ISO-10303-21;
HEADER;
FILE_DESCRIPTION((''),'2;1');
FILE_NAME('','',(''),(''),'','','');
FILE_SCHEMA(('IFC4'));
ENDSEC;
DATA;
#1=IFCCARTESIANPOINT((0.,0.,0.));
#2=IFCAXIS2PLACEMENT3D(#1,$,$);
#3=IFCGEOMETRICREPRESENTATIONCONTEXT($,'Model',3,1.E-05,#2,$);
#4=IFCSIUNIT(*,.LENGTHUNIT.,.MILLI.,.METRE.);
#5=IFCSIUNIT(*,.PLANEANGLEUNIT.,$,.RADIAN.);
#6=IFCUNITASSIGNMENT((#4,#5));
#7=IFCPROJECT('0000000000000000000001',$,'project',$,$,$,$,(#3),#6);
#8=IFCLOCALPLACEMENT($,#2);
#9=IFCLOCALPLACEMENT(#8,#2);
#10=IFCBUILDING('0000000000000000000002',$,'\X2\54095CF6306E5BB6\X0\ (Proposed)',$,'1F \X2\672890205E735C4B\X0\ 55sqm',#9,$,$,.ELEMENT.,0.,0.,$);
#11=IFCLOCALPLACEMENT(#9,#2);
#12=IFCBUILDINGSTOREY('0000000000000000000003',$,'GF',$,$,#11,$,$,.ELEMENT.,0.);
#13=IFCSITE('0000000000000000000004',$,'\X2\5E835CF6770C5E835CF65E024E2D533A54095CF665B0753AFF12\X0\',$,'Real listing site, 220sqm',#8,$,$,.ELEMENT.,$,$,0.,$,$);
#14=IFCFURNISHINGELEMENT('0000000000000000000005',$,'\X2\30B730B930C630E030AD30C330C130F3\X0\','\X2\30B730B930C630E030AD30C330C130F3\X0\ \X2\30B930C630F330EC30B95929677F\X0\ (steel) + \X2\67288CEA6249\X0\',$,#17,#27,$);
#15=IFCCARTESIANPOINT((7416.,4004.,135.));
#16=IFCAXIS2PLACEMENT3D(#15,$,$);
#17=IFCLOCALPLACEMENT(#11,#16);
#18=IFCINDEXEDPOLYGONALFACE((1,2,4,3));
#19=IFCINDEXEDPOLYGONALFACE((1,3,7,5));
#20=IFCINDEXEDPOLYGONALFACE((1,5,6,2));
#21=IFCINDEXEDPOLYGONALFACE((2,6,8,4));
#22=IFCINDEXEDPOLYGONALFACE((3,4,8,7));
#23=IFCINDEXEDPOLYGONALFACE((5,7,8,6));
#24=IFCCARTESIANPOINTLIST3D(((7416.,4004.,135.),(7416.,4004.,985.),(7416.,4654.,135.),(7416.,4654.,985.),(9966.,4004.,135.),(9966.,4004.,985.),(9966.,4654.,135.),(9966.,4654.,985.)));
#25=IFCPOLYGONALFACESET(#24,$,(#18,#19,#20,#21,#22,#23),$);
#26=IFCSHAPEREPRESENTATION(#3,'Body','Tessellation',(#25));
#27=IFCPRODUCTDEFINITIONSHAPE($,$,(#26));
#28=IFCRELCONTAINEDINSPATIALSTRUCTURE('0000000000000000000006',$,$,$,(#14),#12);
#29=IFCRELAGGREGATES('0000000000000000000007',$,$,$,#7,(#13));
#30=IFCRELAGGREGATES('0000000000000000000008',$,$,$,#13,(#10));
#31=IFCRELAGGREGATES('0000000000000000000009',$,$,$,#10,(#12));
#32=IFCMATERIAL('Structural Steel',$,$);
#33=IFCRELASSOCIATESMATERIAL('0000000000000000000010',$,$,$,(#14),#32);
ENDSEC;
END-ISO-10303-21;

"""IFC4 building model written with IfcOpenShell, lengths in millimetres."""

from ifc_helpers import new_model, si_unit, frame, frame_2d, origin, place, context, project, spatial, rectangle, extrude, material, element, save


model = new_model("IFC4")

# Units and contexts
model_context = context("Model", 3, precision=1e-05, world=origin())
ifc_project = project(units=[si_unit("LENGTHUNIT", "METRE", prefix="MILLI"), si_unit("PLANEANGLEUNIT", "RADIAN")], contexts=[model_context])

# Site, building, storey
site_placement = place(None, origin())
site = spatial("IfcSite", under=ifc_project, at=site_placement, Name="広島県広島市中区吉島新町２", ObjectType="Real listing site, 220sqm", CompositionType="ELEMENT", RefElevation=0.0)
building_placement = place(site_placement, origin())
building = spatial("IfcBuilding", under=site, at=building_placement, Name="吉島の家 (Proposed)", ObjectType="1F 木造平屋 55sqm", CompositionType="ELEMENT", ElevationOfRefHeight=0.0, ElevationOfTerrain=0.0)
storey_placement = place(building_placement, origin())
storey = spatial("IfcBuildingStorey", under=building, at=storey_placement, Name="GF", CompositionType="ELEMENT", Elevation=0.0)

# Shared definitions
ifc_material_1 = material(Name="Structural Steel")

# Furnishing element
furnishing_1_placement = place(storey_placement, frame((7416.0, 4004.0, 135.0)))
element("IfcFurnishingElement", 1, at=furnishing_1_placement, inside=storey, material=ifc_material_1, Name="システムキッチン", Description="システムキッチン ステンレス天板 (steel) + 木質扉", context=model_context, shape_type="SweptSolid", body=[
    extrude(rectangle(XDim=2550.0, YDim=650.0, at=frame_2d((1275.0, 325.0))), frame((7416.0, 4004.0, 135.0)), (0.0, 0.0, 1.0), 850.0),
])

save(model, "model.ifc")
